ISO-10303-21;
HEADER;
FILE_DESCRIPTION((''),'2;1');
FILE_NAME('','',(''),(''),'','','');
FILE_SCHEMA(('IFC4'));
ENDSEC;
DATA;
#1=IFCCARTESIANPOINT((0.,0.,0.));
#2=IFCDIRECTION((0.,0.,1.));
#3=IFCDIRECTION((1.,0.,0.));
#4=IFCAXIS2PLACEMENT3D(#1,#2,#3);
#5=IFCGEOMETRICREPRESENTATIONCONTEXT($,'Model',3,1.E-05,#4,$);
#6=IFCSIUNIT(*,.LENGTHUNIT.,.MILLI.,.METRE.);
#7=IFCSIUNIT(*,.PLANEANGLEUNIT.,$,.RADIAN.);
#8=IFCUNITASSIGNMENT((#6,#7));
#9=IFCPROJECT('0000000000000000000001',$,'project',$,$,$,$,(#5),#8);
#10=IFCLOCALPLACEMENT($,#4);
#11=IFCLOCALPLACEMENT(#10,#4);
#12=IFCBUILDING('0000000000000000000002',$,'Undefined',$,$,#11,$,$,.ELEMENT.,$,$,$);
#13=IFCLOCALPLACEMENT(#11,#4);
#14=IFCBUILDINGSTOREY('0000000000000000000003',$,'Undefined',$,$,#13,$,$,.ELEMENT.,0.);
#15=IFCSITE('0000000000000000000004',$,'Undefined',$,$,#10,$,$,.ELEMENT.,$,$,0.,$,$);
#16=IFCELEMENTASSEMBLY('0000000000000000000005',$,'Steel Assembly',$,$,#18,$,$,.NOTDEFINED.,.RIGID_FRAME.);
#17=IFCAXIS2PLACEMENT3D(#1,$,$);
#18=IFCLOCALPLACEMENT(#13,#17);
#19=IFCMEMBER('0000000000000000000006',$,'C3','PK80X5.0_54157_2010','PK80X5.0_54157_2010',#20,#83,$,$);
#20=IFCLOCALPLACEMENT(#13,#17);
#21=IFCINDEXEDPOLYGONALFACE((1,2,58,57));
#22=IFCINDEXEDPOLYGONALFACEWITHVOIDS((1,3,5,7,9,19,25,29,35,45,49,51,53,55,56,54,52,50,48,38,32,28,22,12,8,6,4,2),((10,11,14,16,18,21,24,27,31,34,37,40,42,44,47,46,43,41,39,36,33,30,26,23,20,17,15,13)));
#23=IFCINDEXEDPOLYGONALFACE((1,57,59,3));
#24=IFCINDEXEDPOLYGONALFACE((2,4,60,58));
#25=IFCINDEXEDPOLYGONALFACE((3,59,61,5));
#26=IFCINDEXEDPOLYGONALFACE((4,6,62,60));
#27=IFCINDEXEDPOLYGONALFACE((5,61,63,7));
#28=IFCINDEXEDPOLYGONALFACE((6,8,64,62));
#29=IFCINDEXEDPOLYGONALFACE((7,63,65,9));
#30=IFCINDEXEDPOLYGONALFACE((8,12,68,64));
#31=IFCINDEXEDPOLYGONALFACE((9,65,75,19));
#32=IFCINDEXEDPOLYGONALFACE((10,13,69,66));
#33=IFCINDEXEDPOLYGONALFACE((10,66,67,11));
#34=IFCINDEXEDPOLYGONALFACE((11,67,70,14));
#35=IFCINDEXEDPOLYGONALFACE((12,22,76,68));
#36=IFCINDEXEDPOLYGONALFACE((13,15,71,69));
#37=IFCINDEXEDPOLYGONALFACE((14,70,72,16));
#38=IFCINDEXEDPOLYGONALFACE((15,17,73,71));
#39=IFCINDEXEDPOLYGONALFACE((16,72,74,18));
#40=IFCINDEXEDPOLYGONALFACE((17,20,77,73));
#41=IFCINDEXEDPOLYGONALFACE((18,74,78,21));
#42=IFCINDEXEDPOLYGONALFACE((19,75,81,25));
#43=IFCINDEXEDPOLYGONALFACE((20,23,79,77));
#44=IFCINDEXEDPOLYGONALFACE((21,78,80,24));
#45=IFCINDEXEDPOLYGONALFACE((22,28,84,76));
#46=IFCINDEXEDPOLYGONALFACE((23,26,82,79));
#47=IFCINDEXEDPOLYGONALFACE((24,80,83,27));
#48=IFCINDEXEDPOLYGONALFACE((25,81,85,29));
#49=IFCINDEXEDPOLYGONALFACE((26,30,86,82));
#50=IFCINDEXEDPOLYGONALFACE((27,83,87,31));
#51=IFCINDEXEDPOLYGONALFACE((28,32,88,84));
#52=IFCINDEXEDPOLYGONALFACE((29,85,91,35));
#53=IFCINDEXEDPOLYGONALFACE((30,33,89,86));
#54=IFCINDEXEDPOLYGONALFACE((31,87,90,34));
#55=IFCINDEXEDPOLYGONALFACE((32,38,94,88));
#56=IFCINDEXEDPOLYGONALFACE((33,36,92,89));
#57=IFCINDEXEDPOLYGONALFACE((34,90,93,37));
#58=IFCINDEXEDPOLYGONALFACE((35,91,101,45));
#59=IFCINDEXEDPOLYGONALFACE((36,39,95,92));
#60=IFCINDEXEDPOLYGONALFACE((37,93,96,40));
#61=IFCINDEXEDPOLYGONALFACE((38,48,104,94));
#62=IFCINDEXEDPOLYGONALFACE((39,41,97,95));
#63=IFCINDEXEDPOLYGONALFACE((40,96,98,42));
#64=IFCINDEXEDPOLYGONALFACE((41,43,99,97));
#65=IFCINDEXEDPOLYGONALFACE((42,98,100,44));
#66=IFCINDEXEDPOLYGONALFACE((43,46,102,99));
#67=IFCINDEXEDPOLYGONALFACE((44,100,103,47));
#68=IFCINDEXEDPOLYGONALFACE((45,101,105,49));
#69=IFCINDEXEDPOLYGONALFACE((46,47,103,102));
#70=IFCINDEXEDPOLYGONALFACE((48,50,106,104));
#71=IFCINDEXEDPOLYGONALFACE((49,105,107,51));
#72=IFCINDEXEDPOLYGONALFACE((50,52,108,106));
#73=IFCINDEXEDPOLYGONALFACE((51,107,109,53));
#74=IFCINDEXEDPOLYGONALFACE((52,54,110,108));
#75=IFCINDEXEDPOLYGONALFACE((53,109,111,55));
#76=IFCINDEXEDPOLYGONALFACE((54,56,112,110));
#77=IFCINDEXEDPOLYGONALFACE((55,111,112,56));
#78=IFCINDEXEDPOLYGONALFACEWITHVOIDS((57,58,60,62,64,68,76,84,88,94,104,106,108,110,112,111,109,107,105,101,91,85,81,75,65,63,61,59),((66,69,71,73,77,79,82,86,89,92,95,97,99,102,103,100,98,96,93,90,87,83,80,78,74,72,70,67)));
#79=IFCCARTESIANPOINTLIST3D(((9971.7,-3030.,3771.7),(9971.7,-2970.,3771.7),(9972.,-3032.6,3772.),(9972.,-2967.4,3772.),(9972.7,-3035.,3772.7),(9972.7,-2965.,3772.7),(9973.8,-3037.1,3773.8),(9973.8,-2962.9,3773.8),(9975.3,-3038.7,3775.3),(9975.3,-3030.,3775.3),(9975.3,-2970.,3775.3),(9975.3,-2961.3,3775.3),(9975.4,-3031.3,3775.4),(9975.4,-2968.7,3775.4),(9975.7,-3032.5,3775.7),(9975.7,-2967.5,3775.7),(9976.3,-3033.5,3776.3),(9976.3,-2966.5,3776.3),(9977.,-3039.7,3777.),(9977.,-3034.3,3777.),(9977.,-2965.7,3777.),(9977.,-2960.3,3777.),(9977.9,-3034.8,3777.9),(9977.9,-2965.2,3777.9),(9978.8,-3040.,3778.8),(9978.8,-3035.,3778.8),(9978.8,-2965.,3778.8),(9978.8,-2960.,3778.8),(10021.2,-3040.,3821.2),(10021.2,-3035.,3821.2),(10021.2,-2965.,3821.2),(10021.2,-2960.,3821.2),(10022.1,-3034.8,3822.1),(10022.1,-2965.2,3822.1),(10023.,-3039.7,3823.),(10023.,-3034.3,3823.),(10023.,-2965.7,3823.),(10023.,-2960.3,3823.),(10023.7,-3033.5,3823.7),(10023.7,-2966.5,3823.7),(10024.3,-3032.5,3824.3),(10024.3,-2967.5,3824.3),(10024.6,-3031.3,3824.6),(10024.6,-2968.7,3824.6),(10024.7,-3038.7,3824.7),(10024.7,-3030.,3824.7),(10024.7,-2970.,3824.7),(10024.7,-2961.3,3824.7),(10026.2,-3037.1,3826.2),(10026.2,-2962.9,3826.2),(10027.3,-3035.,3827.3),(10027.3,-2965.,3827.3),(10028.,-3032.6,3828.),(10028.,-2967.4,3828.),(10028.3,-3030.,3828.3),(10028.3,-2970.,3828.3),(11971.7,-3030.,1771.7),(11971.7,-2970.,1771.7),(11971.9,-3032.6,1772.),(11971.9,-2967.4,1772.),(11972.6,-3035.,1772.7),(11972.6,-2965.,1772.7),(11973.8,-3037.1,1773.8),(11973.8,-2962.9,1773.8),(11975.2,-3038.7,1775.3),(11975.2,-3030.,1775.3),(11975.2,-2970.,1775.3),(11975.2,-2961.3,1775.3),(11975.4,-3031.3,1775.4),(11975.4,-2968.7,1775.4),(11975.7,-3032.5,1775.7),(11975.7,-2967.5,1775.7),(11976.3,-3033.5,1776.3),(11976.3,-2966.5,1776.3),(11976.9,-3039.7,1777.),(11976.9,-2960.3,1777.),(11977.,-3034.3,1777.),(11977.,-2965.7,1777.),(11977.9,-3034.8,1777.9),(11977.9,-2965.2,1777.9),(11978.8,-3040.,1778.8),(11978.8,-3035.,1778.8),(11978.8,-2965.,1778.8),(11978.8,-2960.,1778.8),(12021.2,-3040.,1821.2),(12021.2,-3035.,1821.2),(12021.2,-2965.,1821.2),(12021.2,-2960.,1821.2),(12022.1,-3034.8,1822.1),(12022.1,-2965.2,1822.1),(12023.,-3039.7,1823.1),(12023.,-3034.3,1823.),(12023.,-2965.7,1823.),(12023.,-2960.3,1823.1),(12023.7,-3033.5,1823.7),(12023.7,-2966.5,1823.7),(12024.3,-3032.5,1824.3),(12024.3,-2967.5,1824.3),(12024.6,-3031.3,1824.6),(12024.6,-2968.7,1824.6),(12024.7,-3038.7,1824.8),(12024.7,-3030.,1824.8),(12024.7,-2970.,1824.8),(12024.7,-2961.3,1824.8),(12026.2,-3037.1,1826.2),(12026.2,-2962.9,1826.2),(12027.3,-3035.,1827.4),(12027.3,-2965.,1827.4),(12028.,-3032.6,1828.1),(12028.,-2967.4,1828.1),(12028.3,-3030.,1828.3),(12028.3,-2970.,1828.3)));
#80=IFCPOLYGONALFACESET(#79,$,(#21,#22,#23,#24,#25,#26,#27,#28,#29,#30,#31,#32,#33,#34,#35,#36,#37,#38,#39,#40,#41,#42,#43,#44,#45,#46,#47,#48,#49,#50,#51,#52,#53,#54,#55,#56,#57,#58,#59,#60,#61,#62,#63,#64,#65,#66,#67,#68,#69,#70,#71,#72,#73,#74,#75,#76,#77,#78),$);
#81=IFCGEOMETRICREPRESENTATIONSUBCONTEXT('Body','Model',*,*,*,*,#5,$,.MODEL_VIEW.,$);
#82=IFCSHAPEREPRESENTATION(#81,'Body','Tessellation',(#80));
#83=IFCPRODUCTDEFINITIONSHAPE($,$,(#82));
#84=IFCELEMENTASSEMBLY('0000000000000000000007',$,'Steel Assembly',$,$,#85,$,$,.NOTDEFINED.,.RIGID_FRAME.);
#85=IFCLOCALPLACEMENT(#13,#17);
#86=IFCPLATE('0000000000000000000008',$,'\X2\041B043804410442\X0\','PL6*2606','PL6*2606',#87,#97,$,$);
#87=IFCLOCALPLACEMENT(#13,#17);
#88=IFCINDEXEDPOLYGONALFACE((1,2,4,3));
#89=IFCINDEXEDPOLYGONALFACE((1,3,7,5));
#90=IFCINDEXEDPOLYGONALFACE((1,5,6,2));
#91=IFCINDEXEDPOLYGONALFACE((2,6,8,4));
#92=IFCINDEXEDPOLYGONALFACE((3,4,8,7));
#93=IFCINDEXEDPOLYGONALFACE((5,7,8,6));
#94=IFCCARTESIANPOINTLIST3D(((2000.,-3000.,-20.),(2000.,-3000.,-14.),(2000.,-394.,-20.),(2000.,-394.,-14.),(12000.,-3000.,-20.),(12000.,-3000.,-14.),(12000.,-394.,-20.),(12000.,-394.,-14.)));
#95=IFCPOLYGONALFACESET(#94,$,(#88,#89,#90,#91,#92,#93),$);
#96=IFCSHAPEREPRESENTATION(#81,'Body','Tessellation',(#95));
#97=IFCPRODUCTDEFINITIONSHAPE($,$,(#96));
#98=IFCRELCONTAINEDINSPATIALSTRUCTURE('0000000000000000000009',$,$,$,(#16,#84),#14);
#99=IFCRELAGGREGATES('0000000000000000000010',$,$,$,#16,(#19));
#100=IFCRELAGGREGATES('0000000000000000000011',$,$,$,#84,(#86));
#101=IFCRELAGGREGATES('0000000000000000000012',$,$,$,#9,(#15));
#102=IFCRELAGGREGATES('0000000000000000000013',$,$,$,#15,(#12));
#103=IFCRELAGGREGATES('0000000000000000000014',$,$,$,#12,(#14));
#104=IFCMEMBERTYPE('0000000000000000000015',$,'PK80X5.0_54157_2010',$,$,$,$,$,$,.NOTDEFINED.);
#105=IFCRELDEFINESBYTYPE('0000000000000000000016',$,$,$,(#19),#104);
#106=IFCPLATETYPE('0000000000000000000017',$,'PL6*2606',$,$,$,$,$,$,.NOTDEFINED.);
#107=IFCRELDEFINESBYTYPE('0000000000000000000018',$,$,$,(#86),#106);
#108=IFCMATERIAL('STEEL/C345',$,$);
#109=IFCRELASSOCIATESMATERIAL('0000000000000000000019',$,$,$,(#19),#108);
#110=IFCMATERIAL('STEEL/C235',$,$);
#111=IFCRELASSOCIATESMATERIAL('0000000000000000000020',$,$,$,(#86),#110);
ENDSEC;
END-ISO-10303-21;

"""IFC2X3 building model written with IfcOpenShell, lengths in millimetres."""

from ifc_helpers import new_model, si_unit, frame, origin_with_axes, origin_2d_with_axis, place, context, subcontext, project, spatial, polyline, hollow_rectangle, outline, extrude, material, type_object, element, aggregate, save


model = new_model("IFC2X3")

# Units and contexts
model_context = context("Model", 3, precision=1e-05, world=origin_with_axes())
body_context = subcontext(model_context, "Body", "Model", "MODEL_VIEW")
ifc_project = project(units=[si_unit("LENGTHUNIT", "METRE", prefix="MILLI"), si_unit("PLANEANGLEUNIT", "RADIAN")], contexts=[model_context])

# Site, building, storey
site_placement = place(None, origin_with_axes())
site = spatial("IfcSite", under=ifc_project, at=site_placement, Name="Undefined", CompositionType="ELEMENT", RefElevation=0.0)
building_placement = place(site_placement, origin_with_axes())
building = spatial("IfcBuilding", under=site, at=building_placement, Name="Undefined", CompositionType="ELEMENT")
storey_placement = place(building_placement, origin_with_axes())
storey = spatial("IfcBuildingStorey", under=building, at=storey_placement, Name="Undefined", CompositionType="ELEMENT", Elevation=0.0)

# Shared definitions
ifc_material_1 = material(Name="STEEL/C345")
ifc_material_2 = material(Name="STEEL/C235")

# Element assembly, member
assembly_1_placement = place(storey_placement, origin_with_axes())
assembly_1 = element("IfcElementAssembly", 1, at=assembly_1_placement, inside=storey, Name="Steel Assembly", AssemblyPlace="NOTDEFINED", PredefinedType="RIGID_FRAME")
member_type = type_object("IfcMemberType", Name="PK80X5.0_54157_2010", PredefinedType="NOTDEFINED")
member_placement = place(assembly_1_placement, frame((12000.0, -3000.0, 1800.0), z_axis=(0.707107, 0.0, 0.707107), x_axis=(-0.707107, 0.0, 0.707107)))
member = element("IfcMember", 2, at=member_placement, type_object=member_type, material=ifc_material_1, Name="C3", Description="PK80X5.0_54157_2010", ObjectType="PK80X5.0_54157_2010", context=body_context, shape_type="SweptSolid", body=[
    extrude(hollow_rectangle(XDim=80.0, YDim=80.0, WallThickness=5.0, InnerFilletRadius=5.0, OuterFilletRadius=10.0, at=origin_2d_with_axis()), frame((2828.4, 0.0, 0.0), z_axis=(-1.0, 0.0, 0.0), x_axis=(0.0, -1.0, 0.0)), (0.0, 0.0, 1.0), 2828.4),
])
aggregate(assembly_1, [member])

# Element assembly, plate
assembly_2_placement = place(storey_placement, origin_with_axes())
assembly_2 = element("IfcElementAssembly", 3, at=assembly_2_placement, inside=storey, Name="Steel Assembly", AssemblyPlace="NOTDEFINED", PredefinedType="RIGID_FRAME")
plate_type = type_object("IfcPlateType", Name="PL6*2606", PredefinedType="NOTDEFINED")
plate_placement = place(assembly_2_placement, frame((12000.0, -394.0, -17.0), z_axis=(0.0, 0.0, -1.0), x_axis=(0.0, -1.0, 0.0)))
plate = element("IfcPlate", 4, at=plate_placement, type_object=plate_type, material=ifc_material_2, Name="Лист", Description="PL6*2606", ObjectType="PL6*2606", context=body_context, shape_type="SweptSolid", body=[
    extrude(outline(polyline([(0.0, 0.0), (2606.0, 0.0), (2606.0, 10000.0), (0.0, 10000.0), (0.0, 0.0)])), frame((0.0, 0.0, -3.0), z_axis=(0.0, 0.0, 1.0), x_axis=(1.0, 0.0, 0.0)), (0.0, 0.0, 1.0), 6.0),
])
aggregate(assembly_2, [plate])

save(model, "model.ifc")
